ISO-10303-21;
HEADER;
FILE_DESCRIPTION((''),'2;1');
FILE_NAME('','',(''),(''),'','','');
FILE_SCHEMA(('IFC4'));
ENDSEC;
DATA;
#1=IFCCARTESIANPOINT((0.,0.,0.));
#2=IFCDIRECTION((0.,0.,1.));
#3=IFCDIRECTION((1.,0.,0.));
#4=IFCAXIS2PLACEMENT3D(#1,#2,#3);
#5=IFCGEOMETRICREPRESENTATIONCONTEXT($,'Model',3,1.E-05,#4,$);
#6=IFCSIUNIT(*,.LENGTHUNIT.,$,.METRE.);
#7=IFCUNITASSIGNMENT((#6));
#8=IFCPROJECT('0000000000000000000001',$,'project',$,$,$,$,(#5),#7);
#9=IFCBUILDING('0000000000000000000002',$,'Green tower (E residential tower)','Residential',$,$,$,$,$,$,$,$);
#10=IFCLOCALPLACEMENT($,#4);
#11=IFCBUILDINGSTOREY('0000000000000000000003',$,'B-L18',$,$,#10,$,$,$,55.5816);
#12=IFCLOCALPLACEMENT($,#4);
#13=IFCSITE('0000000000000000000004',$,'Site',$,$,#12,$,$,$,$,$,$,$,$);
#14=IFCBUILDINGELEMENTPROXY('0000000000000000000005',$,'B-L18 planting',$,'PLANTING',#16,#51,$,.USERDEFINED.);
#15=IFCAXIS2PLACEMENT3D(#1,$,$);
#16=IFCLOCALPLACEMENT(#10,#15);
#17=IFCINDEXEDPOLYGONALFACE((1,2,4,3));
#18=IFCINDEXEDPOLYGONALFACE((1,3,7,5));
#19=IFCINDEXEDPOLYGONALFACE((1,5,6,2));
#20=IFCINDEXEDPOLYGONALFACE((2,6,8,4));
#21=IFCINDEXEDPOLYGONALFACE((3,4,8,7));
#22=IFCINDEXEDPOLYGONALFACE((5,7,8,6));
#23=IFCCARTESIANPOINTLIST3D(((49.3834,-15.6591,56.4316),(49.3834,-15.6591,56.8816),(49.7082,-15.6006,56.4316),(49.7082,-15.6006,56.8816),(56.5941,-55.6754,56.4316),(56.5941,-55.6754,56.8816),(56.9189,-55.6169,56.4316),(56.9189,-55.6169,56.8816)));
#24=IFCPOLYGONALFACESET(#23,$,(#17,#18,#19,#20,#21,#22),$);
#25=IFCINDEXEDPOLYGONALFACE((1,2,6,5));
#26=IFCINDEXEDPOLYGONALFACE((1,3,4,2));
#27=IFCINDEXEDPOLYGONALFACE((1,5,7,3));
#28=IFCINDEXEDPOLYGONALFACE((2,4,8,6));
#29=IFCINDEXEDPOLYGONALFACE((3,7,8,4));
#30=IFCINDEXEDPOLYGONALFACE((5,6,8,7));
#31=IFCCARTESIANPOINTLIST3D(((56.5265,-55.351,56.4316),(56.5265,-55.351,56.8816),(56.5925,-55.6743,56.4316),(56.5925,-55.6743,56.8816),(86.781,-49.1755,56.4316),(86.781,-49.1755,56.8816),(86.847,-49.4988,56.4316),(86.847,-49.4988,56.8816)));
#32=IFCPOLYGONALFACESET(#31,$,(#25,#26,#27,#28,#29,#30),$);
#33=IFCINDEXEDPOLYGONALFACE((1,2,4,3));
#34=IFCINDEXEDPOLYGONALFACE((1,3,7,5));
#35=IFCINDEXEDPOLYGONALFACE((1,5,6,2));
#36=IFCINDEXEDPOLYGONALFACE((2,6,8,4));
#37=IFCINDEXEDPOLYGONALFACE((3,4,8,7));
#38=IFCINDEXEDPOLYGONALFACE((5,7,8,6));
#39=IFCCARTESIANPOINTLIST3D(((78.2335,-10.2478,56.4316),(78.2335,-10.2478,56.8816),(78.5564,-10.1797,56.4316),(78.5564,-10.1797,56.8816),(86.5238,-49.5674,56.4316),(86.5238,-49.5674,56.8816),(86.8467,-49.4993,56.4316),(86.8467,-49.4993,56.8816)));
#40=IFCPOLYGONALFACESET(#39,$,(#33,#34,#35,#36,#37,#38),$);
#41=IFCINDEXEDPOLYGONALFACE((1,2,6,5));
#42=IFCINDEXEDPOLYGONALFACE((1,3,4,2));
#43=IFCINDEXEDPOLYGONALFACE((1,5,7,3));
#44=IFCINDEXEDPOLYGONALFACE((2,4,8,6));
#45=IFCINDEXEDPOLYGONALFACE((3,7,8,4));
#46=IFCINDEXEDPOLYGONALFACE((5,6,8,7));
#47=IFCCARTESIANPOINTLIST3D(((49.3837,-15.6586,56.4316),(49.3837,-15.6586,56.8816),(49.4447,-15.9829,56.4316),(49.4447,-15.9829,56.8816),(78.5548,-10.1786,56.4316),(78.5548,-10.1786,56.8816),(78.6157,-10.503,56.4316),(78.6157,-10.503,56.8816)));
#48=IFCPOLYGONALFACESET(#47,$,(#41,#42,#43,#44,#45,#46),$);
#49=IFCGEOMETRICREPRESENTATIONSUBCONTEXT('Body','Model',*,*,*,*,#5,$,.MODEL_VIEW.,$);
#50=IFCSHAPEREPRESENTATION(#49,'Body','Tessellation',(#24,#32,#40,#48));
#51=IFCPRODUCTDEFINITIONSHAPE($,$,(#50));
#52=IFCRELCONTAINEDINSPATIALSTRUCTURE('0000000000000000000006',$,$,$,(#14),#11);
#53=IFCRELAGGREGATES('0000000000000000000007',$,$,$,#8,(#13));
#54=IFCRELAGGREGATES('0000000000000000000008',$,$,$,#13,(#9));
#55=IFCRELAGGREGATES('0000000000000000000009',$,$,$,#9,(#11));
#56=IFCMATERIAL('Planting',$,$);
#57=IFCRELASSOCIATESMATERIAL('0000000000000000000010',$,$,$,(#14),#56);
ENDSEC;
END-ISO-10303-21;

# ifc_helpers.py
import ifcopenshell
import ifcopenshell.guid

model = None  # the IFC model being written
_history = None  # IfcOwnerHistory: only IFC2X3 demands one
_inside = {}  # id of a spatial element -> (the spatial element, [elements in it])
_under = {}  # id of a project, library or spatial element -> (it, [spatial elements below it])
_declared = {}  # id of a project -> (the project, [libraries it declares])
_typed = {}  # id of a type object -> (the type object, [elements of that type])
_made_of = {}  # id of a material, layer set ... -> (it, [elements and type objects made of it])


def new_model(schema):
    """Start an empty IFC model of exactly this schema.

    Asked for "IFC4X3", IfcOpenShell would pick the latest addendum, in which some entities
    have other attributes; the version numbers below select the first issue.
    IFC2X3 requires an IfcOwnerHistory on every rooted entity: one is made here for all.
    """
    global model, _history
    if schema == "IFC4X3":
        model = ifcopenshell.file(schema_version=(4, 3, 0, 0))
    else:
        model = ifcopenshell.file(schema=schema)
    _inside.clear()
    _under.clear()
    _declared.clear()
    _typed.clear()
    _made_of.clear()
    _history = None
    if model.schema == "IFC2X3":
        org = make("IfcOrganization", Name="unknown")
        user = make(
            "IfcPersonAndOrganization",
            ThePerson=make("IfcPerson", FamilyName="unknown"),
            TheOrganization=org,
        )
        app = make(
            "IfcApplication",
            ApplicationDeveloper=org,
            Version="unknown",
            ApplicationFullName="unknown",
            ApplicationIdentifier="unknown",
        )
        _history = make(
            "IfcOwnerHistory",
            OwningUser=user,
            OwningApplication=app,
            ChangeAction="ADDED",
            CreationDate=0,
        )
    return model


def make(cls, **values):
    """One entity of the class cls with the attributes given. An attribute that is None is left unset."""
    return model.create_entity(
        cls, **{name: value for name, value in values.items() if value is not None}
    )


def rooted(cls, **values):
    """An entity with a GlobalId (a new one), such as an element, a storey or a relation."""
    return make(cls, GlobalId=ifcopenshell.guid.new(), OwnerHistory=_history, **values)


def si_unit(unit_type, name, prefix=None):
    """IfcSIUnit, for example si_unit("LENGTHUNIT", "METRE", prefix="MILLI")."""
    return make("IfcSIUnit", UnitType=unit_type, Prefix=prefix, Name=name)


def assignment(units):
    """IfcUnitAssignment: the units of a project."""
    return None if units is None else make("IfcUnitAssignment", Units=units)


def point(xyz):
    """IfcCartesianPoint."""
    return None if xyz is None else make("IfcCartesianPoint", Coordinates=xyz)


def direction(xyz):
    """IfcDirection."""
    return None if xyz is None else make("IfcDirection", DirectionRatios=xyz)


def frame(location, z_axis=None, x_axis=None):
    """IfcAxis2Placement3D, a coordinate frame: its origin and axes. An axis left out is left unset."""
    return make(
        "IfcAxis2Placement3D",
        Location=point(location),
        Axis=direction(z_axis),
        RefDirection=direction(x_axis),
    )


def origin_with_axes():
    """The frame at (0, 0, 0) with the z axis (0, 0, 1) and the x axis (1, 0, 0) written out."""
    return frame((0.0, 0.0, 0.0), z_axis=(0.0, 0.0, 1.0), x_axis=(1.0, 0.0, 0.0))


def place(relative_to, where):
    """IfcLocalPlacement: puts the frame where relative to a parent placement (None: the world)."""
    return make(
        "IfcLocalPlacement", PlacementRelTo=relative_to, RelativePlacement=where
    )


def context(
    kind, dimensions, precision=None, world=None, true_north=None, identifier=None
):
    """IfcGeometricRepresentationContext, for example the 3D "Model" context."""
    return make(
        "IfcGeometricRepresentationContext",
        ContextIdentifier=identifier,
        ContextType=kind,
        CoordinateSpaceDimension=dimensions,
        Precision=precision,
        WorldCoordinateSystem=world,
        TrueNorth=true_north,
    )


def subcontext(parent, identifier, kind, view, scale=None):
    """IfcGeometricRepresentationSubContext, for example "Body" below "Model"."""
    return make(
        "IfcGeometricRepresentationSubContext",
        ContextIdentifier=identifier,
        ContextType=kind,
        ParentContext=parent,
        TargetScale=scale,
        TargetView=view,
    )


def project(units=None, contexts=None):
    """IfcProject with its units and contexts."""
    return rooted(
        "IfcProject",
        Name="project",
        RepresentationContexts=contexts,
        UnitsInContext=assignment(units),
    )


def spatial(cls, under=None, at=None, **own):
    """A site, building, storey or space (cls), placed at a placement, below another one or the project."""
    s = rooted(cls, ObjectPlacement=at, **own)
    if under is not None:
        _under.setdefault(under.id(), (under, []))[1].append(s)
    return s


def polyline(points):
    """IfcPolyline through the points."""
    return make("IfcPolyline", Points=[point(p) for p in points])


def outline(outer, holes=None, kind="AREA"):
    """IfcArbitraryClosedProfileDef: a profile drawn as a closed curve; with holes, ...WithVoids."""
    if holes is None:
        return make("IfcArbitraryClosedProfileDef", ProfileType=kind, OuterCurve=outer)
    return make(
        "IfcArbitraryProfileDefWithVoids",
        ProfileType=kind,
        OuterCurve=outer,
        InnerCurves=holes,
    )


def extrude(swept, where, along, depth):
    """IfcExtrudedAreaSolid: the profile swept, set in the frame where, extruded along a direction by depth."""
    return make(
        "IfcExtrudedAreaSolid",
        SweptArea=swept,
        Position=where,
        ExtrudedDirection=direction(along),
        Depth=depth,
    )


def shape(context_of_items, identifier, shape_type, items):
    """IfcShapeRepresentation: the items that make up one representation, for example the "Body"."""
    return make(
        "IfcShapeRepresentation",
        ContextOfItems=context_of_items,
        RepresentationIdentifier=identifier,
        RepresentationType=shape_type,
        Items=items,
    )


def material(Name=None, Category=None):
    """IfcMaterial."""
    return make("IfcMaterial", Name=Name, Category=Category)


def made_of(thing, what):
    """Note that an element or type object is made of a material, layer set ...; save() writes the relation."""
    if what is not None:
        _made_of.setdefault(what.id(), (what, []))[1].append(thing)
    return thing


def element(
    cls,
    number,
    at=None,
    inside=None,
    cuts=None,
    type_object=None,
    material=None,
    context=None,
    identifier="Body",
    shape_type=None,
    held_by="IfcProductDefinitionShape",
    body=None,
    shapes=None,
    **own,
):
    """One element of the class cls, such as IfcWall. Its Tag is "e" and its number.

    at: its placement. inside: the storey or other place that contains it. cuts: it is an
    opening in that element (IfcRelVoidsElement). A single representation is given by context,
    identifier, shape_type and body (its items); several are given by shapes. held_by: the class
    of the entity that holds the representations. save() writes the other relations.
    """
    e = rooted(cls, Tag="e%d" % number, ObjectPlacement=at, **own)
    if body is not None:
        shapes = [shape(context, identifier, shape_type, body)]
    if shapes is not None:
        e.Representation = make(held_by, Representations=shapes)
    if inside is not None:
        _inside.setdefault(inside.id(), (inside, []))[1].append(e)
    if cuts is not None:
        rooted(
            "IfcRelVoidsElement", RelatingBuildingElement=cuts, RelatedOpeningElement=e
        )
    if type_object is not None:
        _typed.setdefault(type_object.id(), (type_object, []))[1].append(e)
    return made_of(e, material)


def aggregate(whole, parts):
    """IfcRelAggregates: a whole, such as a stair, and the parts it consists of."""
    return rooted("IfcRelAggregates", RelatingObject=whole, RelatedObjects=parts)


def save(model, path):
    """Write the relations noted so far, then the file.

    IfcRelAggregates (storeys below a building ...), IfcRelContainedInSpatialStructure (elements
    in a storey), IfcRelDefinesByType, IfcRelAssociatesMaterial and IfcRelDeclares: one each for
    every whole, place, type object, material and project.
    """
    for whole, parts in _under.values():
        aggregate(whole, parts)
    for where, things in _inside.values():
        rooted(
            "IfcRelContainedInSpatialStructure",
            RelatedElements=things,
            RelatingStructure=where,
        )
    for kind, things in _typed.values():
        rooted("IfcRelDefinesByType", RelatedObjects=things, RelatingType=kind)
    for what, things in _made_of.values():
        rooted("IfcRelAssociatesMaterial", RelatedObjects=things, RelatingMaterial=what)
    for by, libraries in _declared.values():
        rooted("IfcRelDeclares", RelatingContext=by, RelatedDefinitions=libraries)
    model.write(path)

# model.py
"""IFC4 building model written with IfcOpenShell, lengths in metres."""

from ifc_helpers import new_model, si_unit, frame, origin_with_axes, place, context, subcontext, project, spatial, polyline, outline, extrude, material, element, save


model = new_model("IFC4")

# Units and contexts
model_context = context("Model", 3, precision=1e-05, world=origin_with_axes())
body_context = subcontext(model_context, "Body", "Model", "MODEL_VIEW")
ifc_project = project(units=[si_unit("LENGTHUNIT", "METRE")], contexts=[model_context])

# Site, building, storey
site_placement = place(None, origin_with_axes())
site = spatial("IfcSite", under=ifc_project, at=site_placement, Name="Site")
building = spatial("IfcBuilding", under=site, Name="Green tower (E residential tower)", Description="Residential")
storey_placement = place(None, origin_with_axes())
storey = spatial("IfcBuildingStorey", under=building, at=storey_placement, Name="B-L18", Elevation=55.5816)

# Building element proxy
ifc_material_1 = material(Name="Planting")
proxy_1_placement = place(storey_placement, origin_with_axes())
element("IfcBuildingElementProxy", 1, at=proxy_1_placement, inside=storey, material=ifc_material_1, Name="B-L18 planting", ObjectType="PLANTING", PredefinedType="USERDEFINED", context=body_context, shape_type="SweptSolid", body=[
    extrude(outline(polyline([(49.3834, -15.6591), (56.5941, -55.6754), (56.9189, -55.6169), (49.7082, -15.6006), (49.3834, -15.6591)])), frame((0.0, 0.0, 56.4316), z_axis=(0.0, 0.0, 1.0), x_axis=(1.0, 0.0, 0.0)), (0.0, 0.0, 1.0), 0.45),
    extrude(outline(polyline([(56.5925, -55.6743), (86.847, -49.4988), (86.781, -49.1755), (56.5265, -55.351), (56.5925, -55.6743)])), frame((0.0, 0.0, 56.4316), z_axis=(0.0, 0.0, 1.0), x_axis=(1.0, 0.0, 0.0)), (0.0, 0.0, 1.0), 0.45),
    extrude(outline(polyline([(86.8467, -49.4993), (78.5564, -10.1797), (78.2335, -10.2478), (86.5238, -49.5674), (86.8467, -49.4993)])), frame((0.0, 0.0, 56.4316), z_axis=(0.0, 0.0, 1.0), x_axis=(1.0, 0.0, 0.0)), (0.0, 0.0, 1.0), 0.45),
    extrude(outline(polyline([(78.5548, -10.1786), (49.3837, -15.6586), (49.4447, -15.9829), (78.6157, -10.503), (78.5548, -10.1786)])), frame((0.0, 0.0, 56.4316), z_axis=(0.0, 0.0, 1.0), x_axis=(1.0, 0.0, 0.0)), (0.0, 0.0, 1.0), 0.45),
])

save(model, "model.ifc")
